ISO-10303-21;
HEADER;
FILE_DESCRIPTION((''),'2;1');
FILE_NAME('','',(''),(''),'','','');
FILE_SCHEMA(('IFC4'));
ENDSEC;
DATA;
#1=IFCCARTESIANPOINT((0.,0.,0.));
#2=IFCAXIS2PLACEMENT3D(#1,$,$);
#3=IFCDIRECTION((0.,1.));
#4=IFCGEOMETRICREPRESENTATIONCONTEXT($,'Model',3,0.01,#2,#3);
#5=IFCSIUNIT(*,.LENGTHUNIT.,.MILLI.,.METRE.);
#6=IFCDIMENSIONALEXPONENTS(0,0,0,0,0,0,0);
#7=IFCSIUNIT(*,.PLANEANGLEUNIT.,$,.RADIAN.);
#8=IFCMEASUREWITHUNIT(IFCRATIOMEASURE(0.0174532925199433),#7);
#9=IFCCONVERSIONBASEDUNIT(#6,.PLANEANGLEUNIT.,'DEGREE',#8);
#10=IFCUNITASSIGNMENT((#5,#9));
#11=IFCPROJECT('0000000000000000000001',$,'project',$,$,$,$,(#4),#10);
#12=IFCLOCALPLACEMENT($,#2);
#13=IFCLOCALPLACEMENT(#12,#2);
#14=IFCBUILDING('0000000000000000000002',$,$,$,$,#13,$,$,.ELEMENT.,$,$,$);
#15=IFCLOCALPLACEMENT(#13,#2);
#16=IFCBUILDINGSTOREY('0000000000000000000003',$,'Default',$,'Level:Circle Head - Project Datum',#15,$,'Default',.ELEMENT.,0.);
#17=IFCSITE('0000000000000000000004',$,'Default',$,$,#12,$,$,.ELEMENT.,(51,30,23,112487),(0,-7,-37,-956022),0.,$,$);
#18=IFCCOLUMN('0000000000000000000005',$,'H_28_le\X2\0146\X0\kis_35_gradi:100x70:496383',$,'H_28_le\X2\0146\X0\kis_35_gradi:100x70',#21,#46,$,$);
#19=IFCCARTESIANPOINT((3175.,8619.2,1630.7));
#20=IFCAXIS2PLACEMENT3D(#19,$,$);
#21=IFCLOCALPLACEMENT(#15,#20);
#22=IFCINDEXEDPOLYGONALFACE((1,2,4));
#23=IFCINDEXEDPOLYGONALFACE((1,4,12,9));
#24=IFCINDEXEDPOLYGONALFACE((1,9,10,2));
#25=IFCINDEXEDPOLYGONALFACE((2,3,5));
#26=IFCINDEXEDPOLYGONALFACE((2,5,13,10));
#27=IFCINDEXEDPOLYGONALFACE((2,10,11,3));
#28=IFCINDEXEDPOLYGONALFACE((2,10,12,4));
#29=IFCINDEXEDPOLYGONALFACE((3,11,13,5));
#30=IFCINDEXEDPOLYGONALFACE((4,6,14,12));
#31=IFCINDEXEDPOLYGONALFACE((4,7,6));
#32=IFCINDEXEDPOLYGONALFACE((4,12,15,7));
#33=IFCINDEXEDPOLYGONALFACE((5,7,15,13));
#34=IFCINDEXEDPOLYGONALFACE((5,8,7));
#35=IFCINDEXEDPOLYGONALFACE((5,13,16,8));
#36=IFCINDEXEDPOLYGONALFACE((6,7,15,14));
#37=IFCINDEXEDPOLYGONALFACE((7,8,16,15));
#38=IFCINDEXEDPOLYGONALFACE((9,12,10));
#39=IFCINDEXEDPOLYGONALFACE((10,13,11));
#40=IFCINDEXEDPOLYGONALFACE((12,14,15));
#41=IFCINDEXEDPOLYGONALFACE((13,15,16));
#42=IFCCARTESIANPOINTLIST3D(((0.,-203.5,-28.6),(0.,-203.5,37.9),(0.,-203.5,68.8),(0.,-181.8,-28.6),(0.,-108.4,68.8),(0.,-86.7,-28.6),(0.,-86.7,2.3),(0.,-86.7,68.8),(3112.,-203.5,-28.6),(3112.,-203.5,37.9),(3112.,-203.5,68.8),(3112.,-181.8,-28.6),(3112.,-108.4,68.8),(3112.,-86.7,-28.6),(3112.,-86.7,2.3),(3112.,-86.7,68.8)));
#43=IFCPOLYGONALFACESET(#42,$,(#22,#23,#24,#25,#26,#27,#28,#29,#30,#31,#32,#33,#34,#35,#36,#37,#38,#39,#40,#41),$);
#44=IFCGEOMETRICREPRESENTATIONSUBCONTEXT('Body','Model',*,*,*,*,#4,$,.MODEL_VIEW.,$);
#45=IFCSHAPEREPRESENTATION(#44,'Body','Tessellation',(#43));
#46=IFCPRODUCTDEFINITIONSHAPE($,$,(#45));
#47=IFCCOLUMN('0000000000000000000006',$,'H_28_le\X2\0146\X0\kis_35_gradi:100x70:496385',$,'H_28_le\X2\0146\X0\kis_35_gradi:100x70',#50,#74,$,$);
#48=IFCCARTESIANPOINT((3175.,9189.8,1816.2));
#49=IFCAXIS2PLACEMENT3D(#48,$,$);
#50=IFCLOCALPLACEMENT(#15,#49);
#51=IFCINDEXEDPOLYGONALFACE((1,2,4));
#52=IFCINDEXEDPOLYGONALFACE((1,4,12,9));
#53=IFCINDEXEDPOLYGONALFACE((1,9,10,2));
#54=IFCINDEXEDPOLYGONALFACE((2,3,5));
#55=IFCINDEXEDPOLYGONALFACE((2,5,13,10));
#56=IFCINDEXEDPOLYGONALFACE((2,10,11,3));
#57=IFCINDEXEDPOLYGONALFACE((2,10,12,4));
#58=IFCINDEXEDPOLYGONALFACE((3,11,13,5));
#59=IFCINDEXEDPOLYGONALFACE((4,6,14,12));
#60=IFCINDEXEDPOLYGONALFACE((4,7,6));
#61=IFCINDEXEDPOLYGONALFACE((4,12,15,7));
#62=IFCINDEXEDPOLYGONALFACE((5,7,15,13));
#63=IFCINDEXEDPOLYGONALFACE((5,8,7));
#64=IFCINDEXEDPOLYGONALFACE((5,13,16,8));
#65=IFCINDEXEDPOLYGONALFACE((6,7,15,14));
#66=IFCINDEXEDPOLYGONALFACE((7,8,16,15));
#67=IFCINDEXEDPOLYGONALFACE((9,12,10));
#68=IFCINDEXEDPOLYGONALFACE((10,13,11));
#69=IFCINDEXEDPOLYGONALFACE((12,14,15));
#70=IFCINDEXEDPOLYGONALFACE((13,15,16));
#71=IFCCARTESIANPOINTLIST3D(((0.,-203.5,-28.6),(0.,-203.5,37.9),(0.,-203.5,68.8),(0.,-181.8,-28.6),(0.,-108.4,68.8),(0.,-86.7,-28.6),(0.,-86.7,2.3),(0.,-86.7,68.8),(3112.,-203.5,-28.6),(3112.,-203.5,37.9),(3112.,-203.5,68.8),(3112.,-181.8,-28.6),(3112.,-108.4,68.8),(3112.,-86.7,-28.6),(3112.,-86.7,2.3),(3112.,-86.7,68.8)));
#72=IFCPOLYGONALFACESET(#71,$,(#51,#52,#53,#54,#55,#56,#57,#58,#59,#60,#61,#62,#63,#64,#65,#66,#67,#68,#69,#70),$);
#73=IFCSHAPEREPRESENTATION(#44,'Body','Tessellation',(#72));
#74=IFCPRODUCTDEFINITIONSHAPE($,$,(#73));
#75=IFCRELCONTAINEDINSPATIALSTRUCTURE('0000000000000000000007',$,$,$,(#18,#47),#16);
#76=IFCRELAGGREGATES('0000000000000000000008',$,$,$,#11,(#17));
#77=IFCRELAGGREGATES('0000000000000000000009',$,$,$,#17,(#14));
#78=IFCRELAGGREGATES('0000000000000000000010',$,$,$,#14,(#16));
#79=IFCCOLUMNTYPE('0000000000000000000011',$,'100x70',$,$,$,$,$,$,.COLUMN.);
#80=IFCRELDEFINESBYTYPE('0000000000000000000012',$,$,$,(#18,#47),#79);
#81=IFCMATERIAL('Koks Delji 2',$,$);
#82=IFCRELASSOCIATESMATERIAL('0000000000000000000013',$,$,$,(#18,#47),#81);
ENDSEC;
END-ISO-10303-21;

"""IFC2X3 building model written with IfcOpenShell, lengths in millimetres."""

from ifc_helpers import new_model, entity, si_unit, converted_unit, direction, frame, frame_2d, origin, origin_2d_with_axis, place, context, subcontext, project, spatial, rectangle, extrude, boolean, source, transform, mapped, material, type_object, type_shapes, element, save


model = new_model("IFC2X3")

# Units and contexts
model_context = context("Model", 3, precision=0.01, world=origin(), true_north=direction((0.0, 1.0)))
body_context = subcontext(model_context, "Body", "Model", "MODEL_VIEW")
ifc_project = project(units=[si_unit("LENGTHUNIT", "METRE", prefix="MILLI"), converted_unit("PLANEANGLEUNIT", "DEGREE", entity("IfcRatioMeasure", 0.0174532925199433), si_unit("PLANEANGLEUNIT", "RADIAN"), dimensions=[0, 0, 0, 0, 0, 0, 0])], contexts=[model_context])

# Site, building, storey
site_placement = place(None, origin())
site = spatial("IfcSite", under=ifc_project, at=site_placement, Name="Default", CompositionType="ELEMENT", RefLatitude=(51, 30, 23, 112487), RefLongitude=(0, -7, -37, -956022), RefElevation=0.0)
building_placement = place(site_placement, origin())
building = spatial("IfcBuilding", under=site, at=building_placement, CompositionType="ELEMENT")
storey_placement = place(building_placement, origin())
storey = spatial("IfcBuildingStorey", under=building, at=storey_placement, Name="Default", ObjectType="Level:Circle Head - Project Datum", LongName="Default", CompositionType="ELEMENT", Elevation=0.0)

# Columns
ifc_material_1 = material(Name="Koks Delji 2")
column_type = type_object("IfcColumnType", Name="100x70", PredefinedType="COLUMN")
shared_shape_1 = source(origin(), body_context, "Body", "CSG", [
    boolean("DIFFERENCE", extrude(rectangle(XDim=3112.0, YDim=116.7, at=origin_2d_with_axis()), frame((1556.0, -145.1, -28.6)), (0.0, 0.0, 1.0), 97.5), extrude(rectangle(XDim=70.0, YDim=100.0, at=frame_2d((0.0, 0.0), x_axis=(0.0, 1.0))), frame((0.0, -145.1, 20.1), z_axis=(-1.0, 0.0, 0.0), x_axis=(0.0, -0.951057, -0.309017)), (0.0, 0.0, -1.0), 3112.0)),
])
type_shapes(column_type, [shared_shape_1])
for number, where, name in (
    (1, (3175.0, 8619.2, 1630.7), "H_28_leņkis_35_gradi:100x70:496383"),
    (2, (3175.0, 9189.8, 1816.2), "H_28_leņkis_35_gradi:100x70:496385"),
):
    element("IfcColumn", number, at=place(storey_placement, frame(where)), inside=storey, type_object=column_type, material=ifc_material_1, Name=name, ObjectType="H_28_leņkis_35_gradi:100x70", context=body_context, shape_type="MappedRepresentation", body=[
        mapped(shared_shape_1, transform((0.0, 0.0, 0.0), scale=1.0)),
    ])

save(model, "model.ifc")
